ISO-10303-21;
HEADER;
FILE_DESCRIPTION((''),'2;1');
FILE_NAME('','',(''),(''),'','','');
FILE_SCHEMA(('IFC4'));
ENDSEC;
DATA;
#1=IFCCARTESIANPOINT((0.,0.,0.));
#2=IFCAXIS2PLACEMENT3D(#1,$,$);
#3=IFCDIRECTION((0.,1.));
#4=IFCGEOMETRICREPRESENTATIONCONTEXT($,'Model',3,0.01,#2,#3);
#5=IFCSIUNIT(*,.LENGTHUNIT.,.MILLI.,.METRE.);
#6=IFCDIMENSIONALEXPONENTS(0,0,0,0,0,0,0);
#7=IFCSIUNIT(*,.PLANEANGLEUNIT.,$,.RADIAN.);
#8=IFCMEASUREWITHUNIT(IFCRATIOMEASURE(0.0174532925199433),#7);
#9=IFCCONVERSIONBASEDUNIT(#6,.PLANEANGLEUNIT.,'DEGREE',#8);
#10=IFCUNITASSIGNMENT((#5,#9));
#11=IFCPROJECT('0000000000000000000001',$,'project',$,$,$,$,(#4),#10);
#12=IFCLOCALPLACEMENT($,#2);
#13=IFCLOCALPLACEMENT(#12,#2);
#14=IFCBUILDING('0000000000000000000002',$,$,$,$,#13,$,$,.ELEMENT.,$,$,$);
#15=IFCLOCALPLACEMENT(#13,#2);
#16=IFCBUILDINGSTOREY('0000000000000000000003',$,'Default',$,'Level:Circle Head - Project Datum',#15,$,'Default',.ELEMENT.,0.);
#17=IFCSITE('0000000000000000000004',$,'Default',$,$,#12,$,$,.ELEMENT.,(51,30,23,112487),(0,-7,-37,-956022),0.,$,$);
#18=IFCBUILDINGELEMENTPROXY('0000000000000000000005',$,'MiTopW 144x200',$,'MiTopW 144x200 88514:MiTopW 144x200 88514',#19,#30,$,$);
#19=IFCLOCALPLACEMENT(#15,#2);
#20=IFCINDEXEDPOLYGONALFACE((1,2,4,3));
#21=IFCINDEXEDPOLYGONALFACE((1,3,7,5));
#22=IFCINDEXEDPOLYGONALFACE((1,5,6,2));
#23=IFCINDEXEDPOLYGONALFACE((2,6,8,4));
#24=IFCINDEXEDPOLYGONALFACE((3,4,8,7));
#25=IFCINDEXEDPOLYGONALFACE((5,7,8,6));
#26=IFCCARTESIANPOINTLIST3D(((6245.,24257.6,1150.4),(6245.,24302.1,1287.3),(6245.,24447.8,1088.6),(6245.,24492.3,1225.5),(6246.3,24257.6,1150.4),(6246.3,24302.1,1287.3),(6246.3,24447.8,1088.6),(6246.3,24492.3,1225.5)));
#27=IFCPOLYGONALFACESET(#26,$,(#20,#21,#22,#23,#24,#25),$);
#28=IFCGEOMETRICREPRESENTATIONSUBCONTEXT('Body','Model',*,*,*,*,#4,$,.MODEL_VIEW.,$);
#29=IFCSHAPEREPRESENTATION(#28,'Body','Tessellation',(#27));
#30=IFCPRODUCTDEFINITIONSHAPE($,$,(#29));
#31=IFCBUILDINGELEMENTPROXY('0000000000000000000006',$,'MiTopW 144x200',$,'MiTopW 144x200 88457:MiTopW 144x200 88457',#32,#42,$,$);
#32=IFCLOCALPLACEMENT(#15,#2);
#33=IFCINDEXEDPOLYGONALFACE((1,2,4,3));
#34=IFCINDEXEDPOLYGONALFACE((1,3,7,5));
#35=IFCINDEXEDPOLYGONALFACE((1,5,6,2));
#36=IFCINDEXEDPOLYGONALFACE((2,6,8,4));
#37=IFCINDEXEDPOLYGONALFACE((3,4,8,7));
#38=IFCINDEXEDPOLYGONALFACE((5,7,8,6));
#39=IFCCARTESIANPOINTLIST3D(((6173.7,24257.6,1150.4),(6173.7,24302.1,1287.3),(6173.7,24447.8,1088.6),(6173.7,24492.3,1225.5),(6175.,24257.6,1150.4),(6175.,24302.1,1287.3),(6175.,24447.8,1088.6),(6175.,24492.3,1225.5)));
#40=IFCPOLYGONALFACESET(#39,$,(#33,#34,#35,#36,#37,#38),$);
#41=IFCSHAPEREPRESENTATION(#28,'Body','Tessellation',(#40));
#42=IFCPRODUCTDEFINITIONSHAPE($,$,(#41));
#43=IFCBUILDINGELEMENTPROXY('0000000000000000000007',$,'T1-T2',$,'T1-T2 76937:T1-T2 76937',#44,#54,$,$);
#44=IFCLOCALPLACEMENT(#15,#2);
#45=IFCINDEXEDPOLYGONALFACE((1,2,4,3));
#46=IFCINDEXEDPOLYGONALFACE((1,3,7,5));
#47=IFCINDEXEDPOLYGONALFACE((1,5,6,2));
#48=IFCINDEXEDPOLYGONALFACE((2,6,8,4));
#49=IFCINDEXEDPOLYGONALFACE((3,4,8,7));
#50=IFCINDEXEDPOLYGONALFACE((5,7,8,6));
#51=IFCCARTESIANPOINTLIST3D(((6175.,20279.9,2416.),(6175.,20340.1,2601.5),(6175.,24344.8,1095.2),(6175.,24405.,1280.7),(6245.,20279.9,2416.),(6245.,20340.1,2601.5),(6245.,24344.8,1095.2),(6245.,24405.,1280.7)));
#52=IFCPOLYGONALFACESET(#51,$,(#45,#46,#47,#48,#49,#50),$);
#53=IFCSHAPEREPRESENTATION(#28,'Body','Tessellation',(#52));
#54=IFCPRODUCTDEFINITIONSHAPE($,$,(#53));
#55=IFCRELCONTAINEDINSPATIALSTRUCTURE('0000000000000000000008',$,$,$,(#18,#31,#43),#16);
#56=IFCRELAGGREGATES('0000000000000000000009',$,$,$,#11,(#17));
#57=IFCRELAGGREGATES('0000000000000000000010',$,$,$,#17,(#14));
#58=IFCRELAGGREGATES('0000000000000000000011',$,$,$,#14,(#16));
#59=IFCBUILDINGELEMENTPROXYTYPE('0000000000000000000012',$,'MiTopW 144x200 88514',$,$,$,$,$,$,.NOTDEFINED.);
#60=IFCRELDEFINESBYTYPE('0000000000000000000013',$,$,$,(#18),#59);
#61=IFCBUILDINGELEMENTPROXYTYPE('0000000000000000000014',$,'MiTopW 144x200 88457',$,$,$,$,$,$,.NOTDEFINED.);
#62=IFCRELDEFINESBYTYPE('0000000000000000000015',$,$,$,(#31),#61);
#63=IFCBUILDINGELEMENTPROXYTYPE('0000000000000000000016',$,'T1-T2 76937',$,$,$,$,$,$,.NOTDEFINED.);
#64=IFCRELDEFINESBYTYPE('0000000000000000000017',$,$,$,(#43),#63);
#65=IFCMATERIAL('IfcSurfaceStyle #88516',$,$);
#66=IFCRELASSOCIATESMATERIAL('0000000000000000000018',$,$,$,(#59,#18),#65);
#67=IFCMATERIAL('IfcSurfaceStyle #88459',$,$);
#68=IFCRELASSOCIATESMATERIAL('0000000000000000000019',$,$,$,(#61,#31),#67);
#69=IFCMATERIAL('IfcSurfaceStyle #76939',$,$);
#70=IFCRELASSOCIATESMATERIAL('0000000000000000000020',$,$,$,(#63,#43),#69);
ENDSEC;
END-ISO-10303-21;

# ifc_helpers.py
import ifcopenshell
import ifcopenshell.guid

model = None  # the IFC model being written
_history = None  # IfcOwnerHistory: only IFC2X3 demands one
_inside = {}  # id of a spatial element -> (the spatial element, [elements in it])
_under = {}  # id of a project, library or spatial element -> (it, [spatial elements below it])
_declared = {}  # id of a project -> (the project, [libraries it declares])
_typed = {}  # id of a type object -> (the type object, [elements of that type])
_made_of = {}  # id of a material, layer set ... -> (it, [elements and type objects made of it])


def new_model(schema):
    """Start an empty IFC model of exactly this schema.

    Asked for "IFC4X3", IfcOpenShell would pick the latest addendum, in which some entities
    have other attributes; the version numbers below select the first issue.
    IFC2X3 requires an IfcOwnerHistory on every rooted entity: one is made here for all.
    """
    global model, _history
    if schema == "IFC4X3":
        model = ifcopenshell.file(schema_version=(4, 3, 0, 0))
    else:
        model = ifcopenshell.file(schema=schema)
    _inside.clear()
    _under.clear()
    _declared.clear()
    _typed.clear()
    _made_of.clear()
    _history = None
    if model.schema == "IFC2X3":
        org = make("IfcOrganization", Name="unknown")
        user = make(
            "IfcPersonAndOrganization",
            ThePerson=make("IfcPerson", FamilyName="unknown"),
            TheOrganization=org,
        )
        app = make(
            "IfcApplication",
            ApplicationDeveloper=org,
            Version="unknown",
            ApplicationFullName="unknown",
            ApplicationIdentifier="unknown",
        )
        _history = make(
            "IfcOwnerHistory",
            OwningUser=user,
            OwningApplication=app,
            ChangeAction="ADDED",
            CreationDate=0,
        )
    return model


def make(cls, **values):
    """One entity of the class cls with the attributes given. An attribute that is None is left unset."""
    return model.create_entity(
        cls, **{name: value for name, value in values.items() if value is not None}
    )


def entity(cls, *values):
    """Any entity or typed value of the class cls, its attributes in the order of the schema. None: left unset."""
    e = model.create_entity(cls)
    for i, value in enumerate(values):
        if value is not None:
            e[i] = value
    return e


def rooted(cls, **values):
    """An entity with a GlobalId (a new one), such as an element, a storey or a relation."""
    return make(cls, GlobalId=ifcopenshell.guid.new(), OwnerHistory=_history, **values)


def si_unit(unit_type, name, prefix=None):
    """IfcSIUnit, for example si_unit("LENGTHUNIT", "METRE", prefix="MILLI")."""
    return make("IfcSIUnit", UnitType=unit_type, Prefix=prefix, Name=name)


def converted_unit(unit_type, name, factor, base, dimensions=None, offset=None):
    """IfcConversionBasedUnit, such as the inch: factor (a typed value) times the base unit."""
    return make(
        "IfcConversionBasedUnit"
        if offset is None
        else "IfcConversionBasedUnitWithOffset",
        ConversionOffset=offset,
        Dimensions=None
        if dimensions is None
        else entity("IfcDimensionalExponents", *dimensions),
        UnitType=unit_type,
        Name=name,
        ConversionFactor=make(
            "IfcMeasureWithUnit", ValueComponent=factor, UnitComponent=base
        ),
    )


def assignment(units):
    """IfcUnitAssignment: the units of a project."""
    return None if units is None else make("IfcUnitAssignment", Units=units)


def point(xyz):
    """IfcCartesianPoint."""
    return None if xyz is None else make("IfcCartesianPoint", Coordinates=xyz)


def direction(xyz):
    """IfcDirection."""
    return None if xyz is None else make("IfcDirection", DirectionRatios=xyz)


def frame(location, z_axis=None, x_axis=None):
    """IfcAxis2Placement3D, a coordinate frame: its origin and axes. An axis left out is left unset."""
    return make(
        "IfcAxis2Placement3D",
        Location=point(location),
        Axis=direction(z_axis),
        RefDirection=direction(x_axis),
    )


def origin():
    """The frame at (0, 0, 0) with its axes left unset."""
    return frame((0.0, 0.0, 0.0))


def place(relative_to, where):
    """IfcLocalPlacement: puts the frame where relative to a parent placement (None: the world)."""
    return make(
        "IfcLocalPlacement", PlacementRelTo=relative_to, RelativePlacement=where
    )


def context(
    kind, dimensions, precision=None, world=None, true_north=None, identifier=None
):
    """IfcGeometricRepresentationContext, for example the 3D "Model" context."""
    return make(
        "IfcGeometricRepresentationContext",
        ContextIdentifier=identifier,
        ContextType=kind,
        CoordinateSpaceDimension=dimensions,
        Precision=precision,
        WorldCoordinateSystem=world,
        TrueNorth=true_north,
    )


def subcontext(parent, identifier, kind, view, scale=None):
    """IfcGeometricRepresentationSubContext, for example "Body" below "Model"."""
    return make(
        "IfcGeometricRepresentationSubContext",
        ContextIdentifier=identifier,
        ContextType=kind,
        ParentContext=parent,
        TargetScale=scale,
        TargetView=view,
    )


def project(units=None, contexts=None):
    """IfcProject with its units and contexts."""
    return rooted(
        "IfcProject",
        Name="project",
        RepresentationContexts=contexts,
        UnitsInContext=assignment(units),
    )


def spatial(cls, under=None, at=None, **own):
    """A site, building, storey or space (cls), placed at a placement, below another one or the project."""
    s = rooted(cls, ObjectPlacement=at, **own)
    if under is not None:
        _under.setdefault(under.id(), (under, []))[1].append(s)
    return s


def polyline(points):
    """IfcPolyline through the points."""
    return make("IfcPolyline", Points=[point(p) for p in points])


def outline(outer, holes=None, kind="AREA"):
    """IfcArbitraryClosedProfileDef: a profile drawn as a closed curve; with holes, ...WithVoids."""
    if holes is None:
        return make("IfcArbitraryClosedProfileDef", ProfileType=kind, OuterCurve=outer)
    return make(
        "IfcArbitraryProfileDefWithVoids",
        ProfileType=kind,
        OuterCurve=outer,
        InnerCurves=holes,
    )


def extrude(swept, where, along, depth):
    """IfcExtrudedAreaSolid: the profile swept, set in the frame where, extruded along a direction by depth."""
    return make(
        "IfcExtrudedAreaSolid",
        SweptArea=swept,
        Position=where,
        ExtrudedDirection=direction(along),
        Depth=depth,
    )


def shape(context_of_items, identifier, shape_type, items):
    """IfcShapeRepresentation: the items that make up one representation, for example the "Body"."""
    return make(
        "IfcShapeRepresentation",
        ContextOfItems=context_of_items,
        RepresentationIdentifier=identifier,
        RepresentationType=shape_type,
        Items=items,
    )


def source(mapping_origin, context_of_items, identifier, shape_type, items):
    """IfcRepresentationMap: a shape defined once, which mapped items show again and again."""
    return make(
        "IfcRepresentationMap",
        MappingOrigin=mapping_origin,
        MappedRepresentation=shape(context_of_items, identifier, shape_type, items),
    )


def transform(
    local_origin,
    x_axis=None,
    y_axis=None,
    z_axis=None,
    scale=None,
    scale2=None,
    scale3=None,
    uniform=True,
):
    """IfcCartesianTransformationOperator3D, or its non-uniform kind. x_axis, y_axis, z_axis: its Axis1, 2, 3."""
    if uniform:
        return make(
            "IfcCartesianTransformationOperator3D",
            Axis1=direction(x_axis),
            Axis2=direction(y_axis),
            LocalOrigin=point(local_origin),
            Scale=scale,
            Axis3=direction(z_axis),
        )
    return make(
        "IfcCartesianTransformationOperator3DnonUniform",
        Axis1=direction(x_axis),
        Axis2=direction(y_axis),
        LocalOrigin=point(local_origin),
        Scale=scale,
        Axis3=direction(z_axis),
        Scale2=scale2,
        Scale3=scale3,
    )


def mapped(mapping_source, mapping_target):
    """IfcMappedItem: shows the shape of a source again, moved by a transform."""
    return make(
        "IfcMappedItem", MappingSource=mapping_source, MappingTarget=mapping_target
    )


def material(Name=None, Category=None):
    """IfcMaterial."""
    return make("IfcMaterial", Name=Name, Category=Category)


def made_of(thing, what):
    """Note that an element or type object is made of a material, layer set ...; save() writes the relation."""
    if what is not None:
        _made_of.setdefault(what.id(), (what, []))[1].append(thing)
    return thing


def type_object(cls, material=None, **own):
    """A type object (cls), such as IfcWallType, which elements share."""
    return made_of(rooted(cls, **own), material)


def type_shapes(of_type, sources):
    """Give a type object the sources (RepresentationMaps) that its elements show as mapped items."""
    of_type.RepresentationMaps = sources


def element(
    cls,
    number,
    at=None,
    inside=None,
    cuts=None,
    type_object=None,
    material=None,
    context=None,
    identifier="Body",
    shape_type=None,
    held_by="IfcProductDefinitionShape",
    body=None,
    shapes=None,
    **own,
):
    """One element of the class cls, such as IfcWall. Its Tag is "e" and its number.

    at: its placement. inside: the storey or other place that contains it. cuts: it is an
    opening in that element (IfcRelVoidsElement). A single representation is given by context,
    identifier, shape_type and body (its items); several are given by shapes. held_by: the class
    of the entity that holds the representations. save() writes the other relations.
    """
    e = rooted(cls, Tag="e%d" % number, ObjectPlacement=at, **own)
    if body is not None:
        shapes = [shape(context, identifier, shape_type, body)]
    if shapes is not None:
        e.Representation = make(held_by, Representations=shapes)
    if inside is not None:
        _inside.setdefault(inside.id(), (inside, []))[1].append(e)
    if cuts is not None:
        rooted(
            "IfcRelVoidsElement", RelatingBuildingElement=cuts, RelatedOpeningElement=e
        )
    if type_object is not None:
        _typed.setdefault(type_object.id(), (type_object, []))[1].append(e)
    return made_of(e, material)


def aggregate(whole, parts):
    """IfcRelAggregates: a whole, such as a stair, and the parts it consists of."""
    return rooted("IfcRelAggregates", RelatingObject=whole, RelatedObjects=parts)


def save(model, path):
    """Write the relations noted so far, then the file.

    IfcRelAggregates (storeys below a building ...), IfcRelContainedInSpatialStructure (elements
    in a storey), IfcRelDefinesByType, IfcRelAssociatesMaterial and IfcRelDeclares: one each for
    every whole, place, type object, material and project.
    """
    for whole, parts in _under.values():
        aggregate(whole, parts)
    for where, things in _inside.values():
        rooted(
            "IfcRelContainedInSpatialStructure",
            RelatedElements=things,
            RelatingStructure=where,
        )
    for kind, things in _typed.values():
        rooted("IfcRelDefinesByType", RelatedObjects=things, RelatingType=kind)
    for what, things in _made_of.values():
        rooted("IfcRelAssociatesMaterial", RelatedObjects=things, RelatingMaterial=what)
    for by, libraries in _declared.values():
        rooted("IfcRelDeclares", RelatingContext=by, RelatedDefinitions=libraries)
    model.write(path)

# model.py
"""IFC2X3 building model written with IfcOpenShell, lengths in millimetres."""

from ifc_helpers import new_model, entity, si_unit, converted_unit, direction, frame, origin, place, context, subcontext, project, spatial, polyline, outline, extrude, source, transform, mapped, material, type_object, type_shapes, element, save


model = new_model("IFC2X3")

# Units and contexts
model_context = context("Model", 3, precision=0.01, world=origin(), true_north=direction((0.0, 1.0)))
body_context = subcontext(model_context, "Body", "Model", "MODEL_VIEW")
ifc_project = project(units=[si_unit("LENGTHUNIT", "METRE", prefix="MILLI"), converted_unit("PLANEANGLEUNIT", "DEGREE", entity("IfcRatioMeasure", 0.0174532925199433), si_unit("PLANEANGLEUNIT", "RADIAN"), dimensions=[0, 0, 0, 0, 0, 0, 0])], contexts=[model_context])

# Site, building, storey
site_placement = place(None, origin())
site = spatial("IfcSite", under=ifc_project, at=site_placement, Name="Default", CompositionType="ELEMENT", RefLatitude=(51, 30, 23, 112487), RefLongitude=(0, -7, -37, -956022), RefElevation=0.0)
building_placement = place(site_placement, origin())
building = spatial("IfcBuilding", under=site, at=building_placement, CompositionType="ELEMENT")
storey_placement = place(building_placement, origin())
storey = spatial("IfcBuildingStorey", under=building, at=storey_placement, Name="Default", ObjectType="Level:Circle Head - Project Datum", LongName="Default", CompositionType="ELEMENT", Elevation=0.0)

# Building element proxies
ifc_material_1 = material(Name="IfcSurfaceStyle #88516")
building_element_proxy_type_1 = type_object("IfcBuildingElementProxyType", Name="MiTopW 144x200 88514", PredefinedType="NOTDEFINED", material=ifc_material_1)
shared_shape_1 = source(origin(), body_context, "Body", "SweptSolid", [
    extrude(outline(polyline([(-100.0, -72.0), (100.0, -72.0), (100.0, 72.0), (-100.0, 72.0), (-100.0, -72.0)])), frame((100.0, 72.0, 0.0), z_axis=(0.0, 0.0, 1.0), x_axis=(-1.0, 0.0, 0.0)), (0.0, 0.0, 1.0), 1.3),
])
type_shapes(building_element_proxy_type_1, [shared_shape_1])
proxy_1_placement = place(building_placement, frame((6246.3, 24447.8, 1088.6), z_axis=(-1.0, 0.0, 0.0), x_axis=(0.0, -0.951057, 0.309017)))
element("IfcBuildingElementProxy", 1, at=proxy_1_placement, inside=storey, type_object=building_element_proxy_type_1, material=ifc_material_1, Name="MiTopW 144x200", ObjectType="MiTopW 144x200 88514:MiTopW 144x200 88514", context=body_context, shape_type="MappedRepresentation", body=[
    mapped(shared_shape_1, transform((0.0, 0.0, 0.0), scale=1.0)),
])
ifc_material_2 = material(Name="IfcSurfaceStyle #88459")
building_element_proxy_type_2 = type_object("IfcBuildingElementProxyType", Name="MiTopW 144x200 88457", PredefinedType="NOTDEFINED", material=ifc_material_2)
shared_shape_2 = source(origin(), body_context, "Body", "SweptSolid", [
    extrude(outline(polyline([(-100.0, -72.0), (100.0, -72.0), (100.0, 72.0), (-100.0, 72.0), (-100.0, -72.0)])), frame((100.0, 72.0, 0.0), z_axis=(0.0, 0.0, 1.0), x_axis=(-1.0, 0.0, 0.0)), (0.0, 0.0, 1.0), 1.3),
])
type_shapes(building_element_proxy_type_2, [shared_shape_2])
proxy_2_placement = place(building_placement, frame((6175.0, 24447.8, 1088.6), z_axis=(-1.0, 0.0, 0.0), x_axis=(0.0, -0.951057, 0.309017)))
element("IfcBuildingElementProxy", 2, at=proxy_2_placement, inside=storey, type_object=building_element_proxy_type_2, material=ifc_material_2, Name="MiTopW 144x200", ObjectType="MiTopW 144x200 88457:MiTopW 144x200 88457", context=body_context, shape_type="MappedRepresentation", body=[
    mapped(shared_shape_2, transform((0.0, 0.0, 0.0), scale=1.0)),
])
ifc_material_3 = material(Name="IfcSurfaceStyle #76939")
building_element_proxy_type_3 = type_object("IfcBuildingElementProxyType", Name="T1-T2 76937", PredefinedType="NOTDEFINED", material=ifc_material_3)
shared_shape_3 = source(origin(), body_context, "Body", "SweptSolid", [
    extrude(outline(polyline([(-2137.0, -97.5), (2137.0, -97.5), (2137.0, 97.5), (-2137.0, 97.5), (-2137.0, -97.5)])), frame((2137.0, 97.5, 0.0), z_axis=(0.0, 0.0, 1.0), x_axis=(-1.0, 0.0, 0.0)), (0.0, 0.0, 1.0), 70.0),
])
type_shapes(building_element_proxy_type_3, [shared_shape_3])
proxy_3_placement = place(building_placement, frame((6245.0, 24344.8, 1095.2), z_axis=(-1.0, 0.0, 0.0), x_axis=(0.0, -0.951057, 0.309017)))
element("IfcBuildingElementProxy", 3, at=proxy_3_placement, inside=storey, type_object=building_element_proxy_type_3, material=ifc_material_3, Name="T1-T2", ObjectType="T1-T2 76937:T1-T2 76937", context=body_context, shape_type="MappedRepresentation", body=[
    mapped(shared_shape_3, transform((0.0, 0.0, 0.0), scale=1.0)),
])

save(model, "model.ifc")
